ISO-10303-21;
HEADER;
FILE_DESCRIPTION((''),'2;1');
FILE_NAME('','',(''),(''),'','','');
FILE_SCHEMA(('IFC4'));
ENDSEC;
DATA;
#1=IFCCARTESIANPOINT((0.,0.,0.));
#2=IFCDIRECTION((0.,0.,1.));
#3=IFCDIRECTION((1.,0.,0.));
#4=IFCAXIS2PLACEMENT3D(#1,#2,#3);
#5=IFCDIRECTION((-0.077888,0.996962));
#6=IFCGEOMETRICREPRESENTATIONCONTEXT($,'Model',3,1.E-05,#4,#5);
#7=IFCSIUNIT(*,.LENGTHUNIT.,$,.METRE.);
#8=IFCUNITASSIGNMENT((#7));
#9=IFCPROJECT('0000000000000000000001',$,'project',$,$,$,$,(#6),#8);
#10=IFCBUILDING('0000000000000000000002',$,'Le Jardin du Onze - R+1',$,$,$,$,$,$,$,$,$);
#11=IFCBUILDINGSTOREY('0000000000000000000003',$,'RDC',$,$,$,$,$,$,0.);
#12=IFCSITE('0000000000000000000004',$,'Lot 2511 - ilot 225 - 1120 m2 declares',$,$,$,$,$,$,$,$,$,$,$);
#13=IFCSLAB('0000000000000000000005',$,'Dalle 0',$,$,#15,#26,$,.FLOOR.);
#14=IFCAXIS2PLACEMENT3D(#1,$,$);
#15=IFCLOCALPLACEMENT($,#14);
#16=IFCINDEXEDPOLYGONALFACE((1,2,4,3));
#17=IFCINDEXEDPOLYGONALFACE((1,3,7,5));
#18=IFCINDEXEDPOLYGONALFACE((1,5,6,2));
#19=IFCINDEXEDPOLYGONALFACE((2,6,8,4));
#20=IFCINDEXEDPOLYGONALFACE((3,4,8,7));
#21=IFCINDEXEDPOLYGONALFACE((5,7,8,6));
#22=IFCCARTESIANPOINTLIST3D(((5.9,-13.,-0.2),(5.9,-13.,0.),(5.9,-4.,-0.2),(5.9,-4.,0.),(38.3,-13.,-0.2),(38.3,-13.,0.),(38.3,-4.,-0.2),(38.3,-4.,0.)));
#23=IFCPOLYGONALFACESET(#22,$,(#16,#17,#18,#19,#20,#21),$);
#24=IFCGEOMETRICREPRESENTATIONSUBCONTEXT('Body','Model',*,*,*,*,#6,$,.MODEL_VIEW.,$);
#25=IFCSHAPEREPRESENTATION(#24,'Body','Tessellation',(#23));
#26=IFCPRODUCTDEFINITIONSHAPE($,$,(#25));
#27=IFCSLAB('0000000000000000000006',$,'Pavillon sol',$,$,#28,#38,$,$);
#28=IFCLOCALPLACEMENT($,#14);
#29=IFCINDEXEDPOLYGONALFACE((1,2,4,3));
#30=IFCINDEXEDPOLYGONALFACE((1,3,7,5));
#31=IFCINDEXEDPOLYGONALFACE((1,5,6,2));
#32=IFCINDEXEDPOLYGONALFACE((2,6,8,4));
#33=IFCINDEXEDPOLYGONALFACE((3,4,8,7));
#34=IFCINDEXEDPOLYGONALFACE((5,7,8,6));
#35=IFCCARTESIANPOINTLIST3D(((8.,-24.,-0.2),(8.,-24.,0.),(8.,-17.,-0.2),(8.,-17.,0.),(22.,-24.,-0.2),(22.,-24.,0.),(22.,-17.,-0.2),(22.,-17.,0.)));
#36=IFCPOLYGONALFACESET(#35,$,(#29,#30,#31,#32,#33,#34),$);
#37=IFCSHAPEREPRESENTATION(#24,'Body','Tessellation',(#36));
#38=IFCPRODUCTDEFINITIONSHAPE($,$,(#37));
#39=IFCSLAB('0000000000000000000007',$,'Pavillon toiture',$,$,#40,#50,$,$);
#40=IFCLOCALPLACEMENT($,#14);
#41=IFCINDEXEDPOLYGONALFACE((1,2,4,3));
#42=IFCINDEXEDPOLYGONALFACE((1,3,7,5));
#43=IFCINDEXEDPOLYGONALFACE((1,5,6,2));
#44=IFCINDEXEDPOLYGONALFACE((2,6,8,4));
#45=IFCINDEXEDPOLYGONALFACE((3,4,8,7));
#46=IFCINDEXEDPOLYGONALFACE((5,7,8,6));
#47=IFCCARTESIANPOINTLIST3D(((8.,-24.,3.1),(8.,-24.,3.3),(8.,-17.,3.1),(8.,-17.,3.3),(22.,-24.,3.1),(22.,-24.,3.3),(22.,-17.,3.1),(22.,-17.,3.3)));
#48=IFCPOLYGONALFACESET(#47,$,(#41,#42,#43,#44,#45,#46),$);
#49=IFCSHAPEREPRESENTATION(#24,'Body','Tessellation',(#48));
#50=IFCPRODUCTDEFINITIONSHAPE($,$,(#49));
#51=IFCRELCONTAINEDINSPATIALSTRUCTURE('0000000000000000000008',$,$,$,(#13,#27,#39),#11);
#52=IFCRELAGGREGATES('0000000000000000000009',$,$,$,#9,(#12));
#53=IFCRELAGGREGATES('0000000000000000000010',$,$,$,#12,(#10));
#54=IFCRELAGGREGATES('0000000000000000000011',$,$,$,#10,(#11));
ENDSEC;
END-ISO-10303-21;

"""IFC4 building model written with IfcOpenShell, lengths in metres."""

from ifc_helpers import new_model, si_unit, direction, frame, origin_with_axes, place, context, subcontext, project, spatial, polyline, outline, extrude, element, save


model = new_model("IFC4")

# Units and contexts
model_context = context("Model", 3, precision=1e-05, world=origin_with_axes(), true_north=direction((-0.077888, 0.996962)))
body_context = subcontext(model_context, "Body", "Model", "MODEL_VIEW")
ifc_project = project(units=[si_unit("LENGTHUNIT", "METRE")], contexts=[model_context])

# Site, building, storey
site = spatial("IfcSite", under=ifc_project, Name="Lot 2511 - ilot 225 - 1120 m2 declares")
building = spatial("IfcBuilding", under=site, Name="Le Jardin du Onze - R+1")
storey = spatial("IfcBuildingStorey", under=building, Name="RDC", Elevation=0.0)

# Slabs
slab_1_placement = place(None, origin_with_axes())
element("IfcSlab", 1, at=slab_1_placement, inside=storey, Name="Dalle 0", PredefinedType="FLOOR", context=body_context, shape_type="SweptSolid", body=[
    extrude(outline(polyline([(38.3, -13.0), (38.3, -4.0), (5.9, -4.0), (5.9, -13.0), (38.3, -13.0)])), frame((0.0, 0.0, -0.2)), (0.0, 0.0, 1.0), 0.2),
])
slab_2_placement = place(None, origin_with_axes())
element("IfcSlab", 2, at=slab_2_placement, inside=storey, Name="Pavillon sol", context=body_context, shape_type="SweptSolid", body=[
    extrude(outline(polyline([(22.0, -24.0), (22.0, -17.0), (8.0, -17.0), (8.0, -24.0), (22.0, -24.0)])), frame((0.0, 0.0, -0.2)), (0.0, 0.0, 1.0), 0.2),
])
slab_3_placement = place(None, origin_with_axes())
element("IfcSlab", 3, at=slab_3_placement, inside=storey, Name="Pavillon toiture", context=body_context, shape_type="SweptSolid", body=[
    extrude(outline(polyline([(22.0, -24.0), (22.0, -17.0), (8.0, -17.0), (8.0, -24.0), (22.0, -24.0)])), frame((0.0, 0.0, 3.1)), (0.0, 0.0, 1.0), 0.2),
])

save(model, "model.ifc")
